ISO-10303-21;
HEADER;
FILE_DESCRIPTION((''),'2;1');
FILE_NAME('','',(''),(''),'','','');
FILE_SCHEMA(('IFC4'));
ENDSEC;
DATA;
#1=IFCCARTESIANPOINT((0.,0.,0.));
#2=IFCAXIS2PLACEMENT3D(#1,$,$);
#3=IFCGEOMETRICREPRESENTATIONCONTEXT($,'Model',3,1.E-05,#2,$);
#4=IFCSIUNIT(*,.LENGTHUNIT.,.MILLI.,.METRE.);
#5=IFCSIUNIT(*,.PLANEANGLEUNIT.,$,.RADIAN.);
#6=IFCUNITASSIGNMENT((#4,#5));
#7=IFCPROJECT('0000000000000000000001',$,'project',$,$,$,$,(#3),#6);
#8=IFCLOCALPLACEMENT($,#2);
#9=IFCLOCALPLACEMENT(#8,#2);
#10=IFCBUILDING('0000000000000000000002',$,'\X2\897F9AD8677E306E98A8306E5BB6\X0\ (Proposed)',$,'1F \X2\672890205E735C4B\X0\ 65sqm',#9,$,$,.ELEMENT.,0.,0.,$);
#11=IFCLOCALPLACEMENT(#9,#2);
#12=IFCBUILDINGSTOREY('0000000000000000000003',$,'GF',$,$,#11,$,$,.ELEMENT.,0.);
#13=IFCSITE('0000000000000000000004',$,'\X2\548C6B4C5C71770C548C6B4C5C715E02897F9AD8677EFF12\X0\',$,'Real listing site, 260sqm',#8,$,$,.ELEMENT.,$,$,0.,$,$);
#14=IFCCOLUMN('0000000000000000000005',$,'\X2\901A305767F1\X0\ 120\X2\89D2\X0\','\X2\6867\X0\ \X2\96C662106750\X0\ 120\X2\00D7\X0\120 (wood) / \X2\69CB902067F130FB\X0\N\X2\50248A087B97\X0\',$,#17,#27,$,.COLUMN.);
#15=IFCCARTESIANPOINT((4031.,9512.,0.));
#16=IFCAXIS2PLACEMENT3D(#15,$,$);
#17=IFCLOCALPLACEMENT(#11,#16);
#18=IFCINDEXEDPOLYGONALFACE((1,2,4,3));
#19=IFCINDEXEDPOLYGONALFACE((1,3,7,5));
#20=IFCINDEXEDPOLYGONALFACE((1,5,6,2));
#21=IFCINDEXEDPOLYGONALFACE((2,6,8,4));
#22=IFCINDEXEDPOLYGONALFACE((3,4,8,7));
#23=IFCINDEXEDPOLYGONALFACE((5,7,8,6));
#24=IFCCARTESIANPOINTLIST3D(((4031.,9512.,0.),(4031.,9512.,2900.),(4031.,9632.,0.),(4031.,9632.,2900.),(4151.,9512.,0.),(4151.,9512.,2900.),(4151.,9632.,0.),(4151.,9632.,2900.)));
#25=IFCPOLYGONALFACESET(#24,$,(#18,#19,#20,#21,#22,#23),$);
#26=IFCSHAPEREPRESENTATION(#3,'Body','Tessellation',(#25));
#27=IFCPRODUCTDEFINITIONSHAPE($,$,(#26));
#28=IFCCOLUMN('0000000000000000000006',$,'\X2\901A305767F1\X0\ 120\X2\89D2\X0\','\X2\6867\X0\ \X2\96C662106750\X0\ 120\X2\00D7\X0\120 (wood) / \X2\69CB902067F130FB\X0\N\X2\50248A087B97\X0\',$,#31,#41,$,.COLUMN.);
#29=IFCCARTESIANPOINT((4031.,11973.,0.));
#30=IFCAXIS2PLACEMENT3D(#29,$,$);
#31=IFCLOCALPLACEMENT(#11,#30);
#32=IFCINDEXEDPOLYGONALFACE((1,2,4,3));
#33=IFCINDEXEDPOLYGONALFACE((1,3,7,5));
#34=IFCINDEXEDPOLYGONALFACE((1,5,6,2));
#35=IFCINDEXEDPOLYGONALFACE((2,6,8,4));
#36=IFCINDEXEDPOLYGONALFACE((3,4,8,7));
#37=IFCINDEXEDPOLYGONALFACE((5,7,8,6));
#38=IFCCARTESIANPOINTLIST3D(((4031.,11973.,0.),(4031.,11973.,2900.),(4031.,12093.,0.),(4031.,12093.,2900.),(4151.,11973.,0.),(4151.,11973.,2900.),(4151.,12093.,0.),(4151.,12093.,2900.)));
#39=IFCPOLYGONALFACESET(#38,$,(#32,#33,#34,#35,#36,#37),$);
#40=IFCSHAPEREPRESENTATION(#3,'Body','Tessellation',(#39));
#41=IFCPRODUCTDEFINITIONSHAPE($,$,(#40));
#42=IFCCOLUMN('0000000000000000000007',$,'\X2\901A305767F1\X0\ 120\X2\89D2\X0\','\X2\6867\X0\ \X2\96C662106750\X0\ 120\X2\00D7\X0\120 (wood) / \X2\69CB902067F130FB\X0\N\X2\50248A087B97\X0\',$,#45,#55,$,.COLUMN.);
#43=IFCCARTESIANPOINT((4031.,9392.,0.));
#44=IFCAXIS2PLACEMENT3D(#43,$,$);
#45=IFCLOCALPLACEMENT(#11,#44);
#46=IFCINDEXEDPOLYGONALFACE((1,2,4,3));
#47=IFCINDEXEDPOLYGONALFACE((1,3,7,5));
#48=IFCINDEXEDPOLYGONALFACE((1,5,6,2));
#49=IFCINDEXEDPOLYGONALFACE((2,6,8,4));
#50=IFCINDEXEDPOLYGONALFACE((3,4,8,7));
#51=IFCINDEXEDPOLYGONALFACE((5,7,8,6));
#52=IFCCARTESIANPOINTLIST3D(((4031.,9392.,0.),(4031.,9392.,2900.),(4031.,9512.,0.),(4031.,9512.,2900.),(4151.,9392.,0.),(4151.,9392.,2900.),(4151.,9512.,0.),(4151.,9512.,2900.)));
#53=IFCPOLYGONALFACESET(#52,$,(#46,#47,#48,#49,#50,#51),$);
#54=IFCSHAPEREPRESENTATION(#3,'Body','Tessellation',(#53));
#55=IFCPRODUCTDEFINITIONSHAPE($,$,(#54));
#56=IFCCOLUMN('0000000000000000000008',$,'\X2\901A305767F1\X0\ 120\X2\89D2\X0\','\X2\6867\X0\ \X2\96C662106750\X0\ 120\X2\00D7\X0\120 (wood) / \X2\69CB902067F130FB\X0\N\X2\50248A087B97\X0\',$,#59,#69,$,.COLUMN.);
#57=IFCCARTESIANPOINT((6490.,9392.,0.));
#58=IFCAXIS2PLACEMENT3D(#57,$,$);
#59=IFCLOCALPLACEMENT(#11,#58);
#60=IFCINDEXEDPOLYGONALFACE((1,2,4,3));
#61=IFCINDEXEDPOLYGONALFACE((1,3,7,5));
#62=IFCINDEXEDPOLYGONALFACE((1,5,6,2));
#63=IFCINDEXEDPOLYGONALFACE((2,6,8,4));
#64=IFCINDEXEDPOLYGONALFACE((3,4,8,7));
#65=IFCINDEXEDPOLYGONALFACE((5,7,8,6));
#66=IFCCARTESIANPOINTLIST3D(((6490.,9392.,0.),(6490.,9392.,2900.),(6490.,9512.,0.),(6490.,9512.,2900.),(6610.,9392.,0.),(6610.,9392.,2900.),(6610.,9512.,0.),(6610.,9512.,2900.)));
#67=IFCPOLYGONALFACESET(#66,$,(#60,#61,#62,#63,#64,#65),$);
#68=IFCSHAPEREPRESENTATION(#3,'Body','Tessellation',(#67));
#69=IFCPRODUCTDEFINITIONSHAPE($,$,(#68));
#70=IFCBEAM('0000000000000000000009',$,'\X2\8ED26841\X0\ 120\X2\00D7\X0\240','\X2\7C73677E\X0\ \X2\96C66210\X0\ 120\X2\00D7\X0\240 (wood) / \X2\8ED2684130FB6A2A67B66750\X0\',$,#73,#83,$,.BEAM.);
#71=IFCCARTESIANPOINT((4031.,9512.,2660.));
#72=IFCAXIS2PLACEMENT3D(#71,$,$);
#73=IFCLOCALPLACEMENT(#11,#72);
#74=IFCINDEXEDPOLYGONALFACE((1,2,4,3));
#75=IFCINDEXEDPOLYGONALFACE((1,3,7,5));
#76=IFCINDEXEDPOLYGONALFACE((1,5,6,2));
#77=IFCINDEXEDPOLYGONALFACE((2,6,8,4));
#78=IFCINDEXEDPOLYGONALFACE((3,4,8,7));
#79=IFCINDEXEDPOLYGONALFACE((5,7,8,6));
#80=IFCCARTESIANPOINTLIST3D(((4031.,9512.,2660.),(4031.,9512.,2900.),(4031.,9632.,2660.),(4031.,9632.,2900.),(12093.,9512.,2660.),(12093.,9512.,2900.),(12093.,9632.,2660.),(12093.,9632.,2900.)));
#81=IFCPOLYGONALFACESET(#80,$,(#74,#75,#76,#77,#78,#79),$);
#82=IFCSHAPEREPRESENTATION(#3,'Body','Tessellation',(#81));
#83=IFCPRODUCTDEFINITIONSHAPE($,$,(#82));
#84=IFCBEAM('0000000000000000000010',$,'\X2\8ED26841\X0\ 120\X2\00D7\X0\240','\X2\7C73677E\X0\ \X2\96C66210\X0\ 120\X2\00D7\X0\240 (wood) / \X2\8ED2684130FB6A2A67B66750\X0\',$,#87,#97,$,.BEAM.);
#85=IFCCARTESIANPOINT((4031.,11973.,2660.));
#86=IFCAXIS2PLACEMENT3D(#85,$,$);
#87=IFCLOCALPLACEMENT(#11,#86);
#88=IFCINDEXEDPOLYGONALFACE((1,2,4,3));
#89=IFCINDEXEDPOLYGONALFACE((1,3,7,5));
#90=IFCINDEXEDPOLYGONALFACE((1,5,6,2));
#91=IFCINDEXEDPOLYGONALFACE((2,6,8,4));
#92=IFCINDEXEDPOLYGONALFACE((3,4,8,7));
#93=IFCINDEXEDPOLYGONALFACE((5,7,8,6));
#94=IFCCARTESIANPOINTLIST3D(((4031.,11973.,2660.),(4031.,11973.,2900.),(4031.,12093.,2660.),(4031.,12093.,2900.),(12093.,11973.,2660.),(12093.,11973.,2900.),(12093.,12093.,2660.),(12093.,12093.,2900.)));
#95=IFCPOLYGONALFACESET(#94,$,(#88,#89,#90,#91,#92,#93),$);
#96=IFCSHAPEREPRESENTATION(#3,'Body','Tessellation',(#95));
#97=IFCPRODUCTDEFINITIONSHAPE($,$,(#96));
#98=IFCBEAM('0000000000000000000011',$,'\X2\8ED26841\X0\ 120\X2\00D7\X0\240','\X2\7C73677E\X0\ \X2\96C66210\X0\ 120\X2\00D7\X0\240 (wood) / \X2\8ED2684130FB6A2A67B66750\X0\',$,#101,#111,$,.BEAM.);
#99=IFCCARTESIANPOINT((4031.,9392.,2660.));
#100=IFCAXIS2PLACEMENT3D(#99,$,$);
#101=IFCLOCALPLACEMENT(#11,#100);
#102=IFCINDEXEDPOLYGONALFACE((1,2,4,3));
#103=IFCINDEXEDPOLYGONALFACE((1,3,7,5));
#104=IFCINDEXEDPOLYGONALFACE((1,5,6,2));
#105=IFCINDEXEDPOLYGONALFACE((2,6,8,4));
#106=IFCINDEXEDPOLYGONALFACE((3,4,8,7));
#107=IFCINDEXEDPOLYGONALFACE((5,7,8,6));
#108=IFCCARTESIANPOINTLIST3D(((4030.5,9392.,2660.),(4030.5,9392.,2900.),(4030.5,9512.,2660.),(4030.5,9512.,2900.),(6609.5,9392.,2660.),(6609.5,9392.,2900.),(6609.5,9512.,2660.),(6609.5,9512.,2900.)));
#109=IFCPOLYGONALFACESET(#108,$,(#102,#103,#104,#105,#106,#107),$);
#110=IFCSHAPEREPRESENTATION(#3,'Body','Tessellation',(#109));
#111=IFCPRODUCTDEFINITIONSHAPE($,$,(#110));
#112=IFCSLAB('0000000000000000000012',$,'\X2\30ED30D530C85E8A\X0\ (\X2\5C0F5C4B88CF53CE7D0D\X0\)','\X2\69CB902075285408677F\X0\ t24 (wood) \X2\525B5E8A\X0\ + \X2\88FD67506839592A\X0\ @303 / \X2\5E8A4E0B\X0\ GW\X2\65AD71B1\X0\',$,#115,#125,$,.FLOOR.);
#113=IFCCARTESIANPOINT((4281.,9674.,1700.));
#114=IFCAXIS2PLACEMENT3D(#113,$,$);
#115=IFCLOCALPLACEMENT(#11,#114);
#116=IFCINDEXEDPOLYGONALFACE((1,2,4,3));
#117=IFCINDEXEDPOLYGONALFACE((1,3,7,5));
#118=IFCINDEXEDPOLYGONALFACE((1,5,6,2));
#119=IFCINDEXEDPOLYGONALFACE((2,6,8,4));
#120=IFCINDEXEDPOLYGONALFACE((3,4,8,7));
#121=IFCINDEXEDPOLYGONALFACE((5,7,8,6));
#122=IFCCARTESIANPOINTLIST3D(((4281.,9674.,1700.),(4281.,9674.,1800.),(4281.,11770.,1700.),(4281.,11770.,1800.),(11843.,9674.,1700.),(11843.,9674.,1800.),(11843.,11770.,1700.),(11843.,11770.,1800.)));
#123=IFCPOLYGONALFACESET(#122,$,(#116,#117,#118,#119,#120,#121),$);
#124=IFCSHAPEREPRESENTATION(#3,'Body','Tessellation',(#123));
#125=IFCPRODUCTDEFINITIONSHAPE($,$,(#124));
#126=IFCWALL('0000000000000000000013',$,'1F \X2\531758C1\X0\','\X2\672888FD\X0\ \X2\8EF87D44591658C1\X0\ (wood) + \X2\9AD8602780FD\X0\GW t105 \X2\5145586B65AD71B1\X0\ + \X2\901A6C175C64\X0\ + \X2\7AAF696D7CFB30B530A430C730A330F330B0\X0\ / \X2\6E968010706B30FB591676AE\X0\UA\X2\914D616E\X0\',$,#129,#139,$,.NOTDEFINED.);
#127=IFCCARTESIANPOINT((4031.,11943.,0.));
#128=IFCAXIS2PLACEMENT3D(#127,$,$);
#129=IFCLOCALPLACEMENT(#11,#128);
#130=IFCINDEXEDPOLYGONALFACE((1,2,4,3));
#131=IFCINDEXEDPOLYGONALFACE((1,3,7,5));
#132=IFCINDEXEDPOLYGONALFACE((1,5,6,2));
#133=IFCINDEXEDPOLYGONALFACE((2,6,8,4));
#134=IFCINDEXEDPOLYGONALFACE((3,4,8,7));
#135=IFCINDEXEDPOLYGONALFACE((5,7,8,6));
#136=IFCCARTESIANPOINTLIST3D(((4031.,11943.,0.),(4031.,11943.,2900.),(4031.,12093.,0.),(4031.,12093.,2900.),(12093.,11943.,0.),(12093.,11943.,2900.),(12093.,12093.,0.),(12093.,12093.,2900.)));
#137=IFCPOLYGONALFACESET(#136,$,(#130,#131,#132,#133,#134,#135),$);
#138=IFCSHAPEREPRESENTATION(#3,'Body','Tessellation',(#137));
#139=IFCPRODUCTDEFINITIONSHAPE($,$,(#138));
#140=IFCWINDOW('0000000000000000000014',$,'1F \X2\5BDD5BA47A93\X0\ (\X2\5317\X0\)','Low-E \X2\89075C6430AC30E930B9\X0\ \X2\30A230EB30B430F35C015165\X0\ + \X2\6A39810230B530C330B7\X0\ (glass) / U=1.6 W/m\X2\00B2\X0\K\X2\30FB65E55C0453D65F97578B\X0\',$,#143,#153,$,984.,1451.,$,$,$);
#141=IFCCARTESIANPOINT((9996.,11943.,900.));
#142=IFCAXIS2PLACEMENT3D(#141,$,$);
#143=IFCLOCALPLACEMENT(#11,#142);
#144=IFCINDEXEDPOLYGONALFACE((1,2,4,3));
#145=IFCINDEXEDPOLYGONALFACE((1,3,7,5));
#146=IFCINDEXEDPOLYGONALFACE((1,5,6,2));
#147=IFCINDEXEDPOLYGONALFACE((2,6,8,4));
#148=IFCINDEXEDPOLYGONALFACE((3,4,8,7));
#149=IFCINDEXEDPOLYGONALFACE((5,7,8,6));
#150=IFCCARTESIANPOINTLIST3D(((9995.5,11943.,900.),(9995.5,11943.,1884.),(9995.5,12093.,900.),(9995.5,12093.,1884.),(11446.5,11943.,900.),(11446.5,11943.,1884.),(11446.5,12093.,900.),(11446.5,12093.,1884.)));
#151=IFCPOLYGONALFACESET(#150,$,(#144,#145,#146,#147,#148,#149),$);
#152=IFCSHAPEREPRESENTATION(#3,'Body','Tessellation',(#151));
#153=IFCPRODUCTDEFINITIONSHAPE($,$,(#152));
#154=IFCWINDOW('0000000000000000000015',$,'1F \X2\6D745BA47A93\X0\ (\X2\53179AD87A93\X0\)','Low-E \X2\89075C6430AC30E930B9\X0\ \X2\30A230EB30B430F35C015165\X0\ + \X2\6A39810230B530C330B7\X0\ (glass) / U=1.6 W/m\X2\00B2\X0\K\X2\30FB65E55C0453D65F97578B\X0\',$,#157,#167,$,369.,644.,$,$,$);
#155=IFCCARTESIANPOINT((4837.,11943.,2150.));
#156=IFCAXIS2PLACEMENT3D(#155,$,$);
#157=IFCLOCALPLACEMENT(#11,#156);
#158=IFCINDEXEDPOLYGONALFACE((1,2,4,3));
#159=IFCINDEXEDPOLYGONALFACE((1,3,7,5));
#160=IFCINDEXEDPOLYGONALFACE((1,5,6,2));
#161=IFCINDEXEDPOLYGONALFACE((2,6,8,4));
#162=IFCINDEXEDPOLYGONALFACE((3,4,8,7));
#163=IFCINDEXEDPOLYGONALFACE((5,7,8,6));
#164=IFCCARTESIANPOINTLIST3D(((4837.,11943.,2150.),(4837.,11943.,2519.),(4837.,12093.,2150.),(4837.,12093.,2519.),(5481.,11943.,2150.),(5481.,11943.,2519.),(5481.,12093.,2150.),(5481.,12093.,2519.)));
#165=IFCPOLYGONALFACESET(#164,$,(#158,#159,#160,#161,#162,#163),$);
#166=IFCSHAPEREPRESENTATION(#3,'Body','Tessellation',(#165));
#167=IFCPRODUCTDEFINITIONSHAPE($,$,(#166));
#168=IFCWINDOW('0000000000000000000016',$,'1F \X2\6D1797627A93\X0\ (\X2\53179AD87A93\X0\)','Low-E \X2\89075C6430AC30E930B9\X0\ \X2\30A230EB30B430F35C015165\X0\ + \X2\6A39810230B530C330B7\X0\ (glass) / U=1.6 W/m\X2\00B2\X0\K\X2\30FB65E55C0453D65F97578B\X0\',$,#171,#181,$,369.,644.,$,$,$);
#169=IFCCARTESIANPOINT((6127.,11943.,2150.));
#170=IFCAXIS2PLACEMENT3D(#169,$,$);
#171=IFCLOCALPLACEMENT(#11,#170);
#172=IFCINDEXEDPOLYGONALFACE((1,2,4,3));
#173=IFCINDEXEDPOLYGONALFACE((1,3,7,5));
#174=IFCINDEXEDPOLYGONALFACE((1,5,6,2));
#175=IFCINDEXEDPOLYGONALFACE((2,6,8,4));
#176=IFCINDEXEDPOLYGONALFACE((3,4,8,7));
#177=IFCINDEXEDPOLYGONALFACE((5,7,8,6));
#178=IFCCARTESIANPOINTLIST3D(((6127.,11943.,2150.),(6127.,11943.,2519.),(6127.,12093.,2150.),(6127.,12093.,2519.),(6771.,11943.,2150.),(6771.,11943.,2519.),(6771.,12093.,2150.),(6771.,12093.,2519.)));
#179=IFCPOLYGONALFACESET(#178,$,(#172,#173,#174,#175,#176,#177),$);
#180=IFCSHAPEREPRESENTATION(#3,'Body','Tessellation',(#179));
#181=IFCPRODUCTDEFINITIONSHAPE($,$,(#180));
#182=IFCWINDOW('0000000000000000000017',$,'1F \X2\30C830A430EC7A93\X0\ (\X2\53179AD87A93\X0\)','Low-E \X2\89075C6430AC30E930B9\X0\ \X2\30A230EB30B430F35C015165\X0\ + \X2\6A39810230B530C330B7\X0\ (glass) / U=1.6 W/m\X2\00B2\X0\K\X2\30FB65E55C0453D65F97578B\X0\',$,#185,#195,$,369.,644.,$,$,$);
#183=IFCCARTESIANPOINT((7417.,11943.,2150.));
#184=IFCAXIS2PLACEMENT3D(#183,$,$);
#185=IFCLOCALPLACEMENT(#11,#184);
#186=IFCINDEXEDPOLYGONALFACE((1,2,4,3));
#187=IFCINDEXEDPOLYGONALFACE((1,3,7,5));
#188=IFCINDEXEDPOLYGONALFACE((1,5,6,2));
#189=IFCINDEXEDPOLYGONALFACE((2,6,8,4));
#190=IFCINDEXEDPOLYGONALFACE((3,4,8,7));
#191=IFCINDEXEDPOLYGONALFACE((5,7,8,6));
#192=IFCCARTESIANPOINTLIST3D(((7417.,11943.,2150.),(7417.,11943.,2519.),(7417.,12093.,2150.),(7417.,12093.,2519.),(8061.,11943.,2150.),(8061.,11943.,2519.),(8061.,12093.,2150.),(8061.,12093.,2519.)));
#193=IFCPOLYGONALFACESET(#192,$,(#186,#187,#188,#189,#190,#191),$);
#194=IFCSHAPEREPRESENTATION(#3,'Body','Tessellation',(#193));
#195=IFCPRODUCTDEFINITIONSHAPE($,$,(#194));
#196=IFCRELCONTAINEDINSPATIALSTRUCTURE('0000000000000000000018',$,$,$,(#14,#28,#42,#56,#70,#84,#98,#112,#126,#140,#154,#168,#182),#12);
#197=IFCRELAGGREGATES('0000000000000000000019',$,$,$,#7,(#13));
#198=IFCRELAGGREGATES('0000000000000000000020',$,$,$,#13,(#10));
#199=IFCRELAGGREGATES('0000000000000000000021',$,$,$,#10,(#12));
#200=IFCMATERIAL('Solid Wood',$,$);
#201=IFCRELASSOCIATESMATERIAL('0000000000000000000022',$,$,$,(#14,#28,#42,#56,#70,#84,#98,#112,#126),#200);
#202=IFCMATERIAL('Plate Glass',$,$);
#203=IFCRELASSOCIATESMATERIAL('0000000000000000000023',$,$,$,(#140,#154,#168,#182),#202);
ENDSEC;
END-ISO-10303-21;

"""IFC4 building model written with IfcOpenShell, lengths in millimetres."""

from ifc_helpers import new_model, si_unit, frame, frame_2d, origin, place, context, project, spatial, rectangle, extrude, material, element, fill, save


model = new_model("IFC4")

# Units and contexts
model_context = context("Model", 3, precision=1e-05, world=origin())
ifc_project = project(units=[si_unit("LENGTHUNIT", "METRE", prefix="MILLI"), si_unit("PLANEANGLEUNIT", "RADIAN")], contexts=[model_context])

# Site, building, storey
site_placement = place(None, origin())
site = spatial("IfcSite", under=ifc_project, at=site_placement, Name="和歌山県和歌山市西高松２", ObjectType="Real listing site, 260sqm", CompositionType="ELEMENT", RefElevation=0.0)
building_placement = place(site_placement, origin())
building = spatial("IfcBuilding", under=site, at=building_placement, Name="西高松の風の家 (Proposed)", ObjectType="1F 木造平屋 65sqm", CompositionType="ELEMENT", ElevationOfRefHeight=0.0, ElevationOfTerrain=0.0)
storey_placement = place(building_placement, origin())
storey = spatial("IfcBuildingStorey", under=building, at=storey_placement, Name="GF", CompositionType="ELEMENT", Elevation=0.0)

# Columns
ifc_material_1 = material(Name="Solid Wood")
column_1_placement = place(storey_placement, frame((4031.0, 9512.0, 0.0)))
element("IfcColumn", 1, at=column_1_placement, inside=storey, material=ifc_material_1, Name="通し柱 120角", Description="桧 集成材 120×120 (wood) / 構造柱・N値計算", PredefinedType="COLUMN", context=model_context, shape_type="SweptSolid", body=[
    extrude(rectangle(XDim=120.0, YDim=120.0, at=frame_2d((60.0, 60.0))), frame((4031.0, 9512.0, 0.0)), (0.0, 0.0, 1.0), 2900.0),
])
column_2_placement = place(storey_placement, frame((4031.0, 11973.0, 0.0)))
element("IfcColumn", 2, at=column_2_placement, inside=storey, material=ifc_material_1, Name="通し柱 120角", Description="桧 集成材 120×120 (wood) / 構造柱・N値計算", PredefinedType="COLUMN", context=model_context, shape_type="SweptSolid", body=[
    extrude(rectangle(XDim=120.0, YDim=120.0, at=frame_2d((60.0, 60.0))), frame((4031.0, 11973.0, 0.0)), (0.0, 0.0, 1.0), 2900.0),
])
column_3_placement = place(storey_placement, frame((4031.0, 9392.0, 0.0)))
element("IfcColumn", 3, at=column_3_placement, inside=storey, material=ifc_material_1, Name="通し柱 120角", Description="桧 集成材 120×120 (wood) / 構造柱・N値計算", PredefinedType="COLUMN", context=model_context, shape_type="SweptSolid", body=[
    extrude(rectangle(XDim=120.0, YDim=120.0, at=frame_2d((60.0, 60.0))), frame((4031.0, 9392.0, 0.0)), (0.0, 0.0, 1.0), 2900.0),
])
column_4_placement = place(storey_placement, frame((6490.0, 9392.0, 0.0)))
element("IfcColumn", 4, at=column_4_placement, inside=storey, material=ifc_material_1, Name="通し柱 120角", Description="桧 集成材 120×120 (wood) / 構造柱・N値計算", PredefinedType="COLUMN", context=model_context, shape_type="SweptSolid", body=[
    extrude(rectangle(XDim=120.0, YDim=120.0, at=frame_2d((60.0, 60.0))), frame((6490.0, 9392.0, 0.0)), (0.0, 0.0, 1.0), 2900.0),
])

# Beams
beam_1_placement = place(storey_placement, frame((4031.0, 9512.0, 2660.0)))
element("IfcBeam", 5, at=beam_1_placement, inside=storey, material=ifc_material_1, Name="軒桁 120×240", Description="米松 集成 120×240 (wood) / 軒桁・横架材", PredefinedType="BEAM", context=model_context, shape_type="SweptSolid", body=[
    extrude(rectangle(XDim=8062.0, YDim=120.0, at=frame_2d((4031.0, 60.0))), frame((4031.0, 9512.0, 2660.0)), (0.0, 0.0, 1.0), 240.0),
])
beam_2_placement = place(storey_placement, frame((4031.0, 11973.0, 2660.0)))
element("IfcBeam", 6, at=beam_2_placement, inside=storey, material=ifc_material_1, Name="軒桁 120×240", Description="米松 集成 120×240 (wood) / 軒桁・横架材", PredefinedType="BEAM", context=model_context, shape_type="SweptSolid", body=[
    extrude(rectangle(XDim=8062.0, YDim=120.0, at=frame_2d((4031.0, 60.0))), frame((4031.0, 11973.0, 2660.0)), (0.0, 0.0, 1.0), 240.0),
])
beam_3_placement = place(storey_placement, frame((4031.0, 9392.0, 2660.0)))
element("IfcBeam", 7, at=beam_3_placement, inside=storey, material=ifc_material_1, Name="軒桁 120×240", Description="米松 集成 120×240 (wood) / 軒桁・横架材", PredefinedType="BEAM", context=model_context, shape_type="SweptSolid", body=[
    extrude(rectangle(XDim=2579.0, YDim=120.0, at=frame_2d((1289.0, 60.0))), frame((4031.0, 9392.0, 2660.0)), (0.0, 0.0, 1.0), 240.0),
])

# Slab
slab_1_placement = place(storey_placement, frame((4281.0, 9674.0, 1700.0)))
element("IfcSlab", 8, at=slab_1_placement, inside=storey, material=ifc_material_1, Name="ロフト床 (小屋裏収納)", Description="構造用合板 t24 (wood) 剛床 + 製材根太 @303 / 床下 GW断熱", PredefinedType="FLOOR", context=model_context, shape_type="SweptSolid", body=[
    extrude(rectangle(XDim=7562.0, YDim=2096.0, at=frame_2d((3781.0, 1048.0))), frame((4281.0, 9674.0, 1700.0)), (0.0, 0.0, 1.0), 100.0),
])

# Wall, openings, windows
wall_1_placement = place(storey_placement, frame((4031.0, 11943.0, 0.0)))
wall_1 = element("IfcWall", 9, at=wall_1_placement, inside=storey, material=ifc_material_1, Name="1F 北壁", Description="木製 軸組外壁 (wood) + 高性能GW t105 充填断熱 + 通気層 + 窯業系サイディング / 準耐火・外皮UA配慮", PredefinedType="NOTDEFINED", context=model_context, shape_type="SweptSolid", body=[
    extrude(rectangle(XDim=8062.0, YDim=150.0, at=frame_2d((4031.0, 75.0))), frame((4031.0, 11943.0, 0.0)), (0.0, 0.0, 1.0), 2900.0),
])
opening_1_placement = place(storey_placement, frame((9996.0, 11943.0, 900.0)))
opening_1 = element("IfcOpeningElement", 10, at=opening_1_placement, cuts=wall_1, PredefinedType="NOTDEFINED", context=model_context, shape_type="SweptSolid", body=[
    extrude(rectangle(XDim=1451.0, YDim=150.0, at=frame_2d((725.0, 75.0))), frame((9996.0, 11943.0, 900.0)), (0.0, 0.0, 1.0), 984.0),
])
opening_2_placement = place(storey_placement, frame((4837.0, 11943.0, 2150.0)))
opening_2 = element("IfcOpeningElement", 11, at=opening_2_placement, cuts=wall_1, PredefinedType="NOTDEFINED", context=model_context, shape_type="SweptSolid", body=[
    extrude(rectangle(XDim=644.0, YDim=150.0, at=frame_2d((322.0, 75.0))), frame((4837.0, 11943.0, 2150.0)), (0.0, 0.0, 1.0), 369.0),
])
opening_3_placement = place(storey_placement, frame((6127.0, 11943.0, 2150.0)))
opening_3 = element("IfcOpeningElement", 12, at=opening_3_placement, cuts=wall_1, PredefinedType="NOTDEFINED", context=model_context, shape_type="SweptSolid", body=[
    extrude(rectangle(XDim=644.0, YDim=150.0, at=frame_2d((322.0, 75.0))), frame((6127.0, 11943.0, 2150.0)), (0.0, 0.0, 1.0), 369.0),
])
opening_4_placement = place(storey_placement, frame((7417.0, 11943.0, 2150.0)))
opening_4 = element("IfcOpeningElement", 13, at=opening_4_placement, cuts=wall_1, PredefinedType="NOTDEFINED", context=model_context, shape_type="SweptSolid", body=[
    extrude(rectangle(XDim=644.0, YDim=150.0, at=frame_2d((322.0, 75.0))), frame((7417.0, 11943.0, 2150.0)), (0.0, 0.0, 1.0), 369.0),
])
ifc_material_2 = material(Name="Plate Glass")
window_1_placement = place(storey_placement, frame((9996.0, 11943.0, 900.0)))
window_1 = element("IfcWindow", 14, at=window_1_placement, inside=storey, material=ifc_material_2, Name="1F 寝室窓 (北)", Description="Low-E 複層ガラス アルゴン封入 + 樹脂サッシ (glass) / U=1.6 W/m²K・日射取得型", OverallHeight=984.0, OverallWidth=1451.0, context=model_context, shape_type="SweptSolid", body=[
    extrude(rectangle(XDim=1451.0, YDim=150.0, at=frame_2d((725.0, 75.0))), frame((9996.0, 11943.0, 900.0)), (0.0, 0.0, 1.0), 984.0),
])
fill(opening_1, window_1)
window_2_placement = place(storey_placement, frame((4837.0, 11943.0, 2150.0)))
window_2 = element("IfcWindow", 15, at=window_2_placement, inside=storey, material=ifc_material_2, Name="1F 浴室窓 (北高窓)", Description="Low-E 複層ガラス アルゴン封入 + 樹脂サッシ (glass) / U=1.6 W/m²K・日射取得型", OverallHeight=369.0, OverallWidth=644.0, context=model_context, shape_type="SweptSolid", body=[
    extrude(rectangle(XDim=644.0, YDim=150.0, at=frame_2d((322.0, 75.0))), frame((4837.0, 11943.0, 2150.0)), (0.0, 0.0, 1.0), 369.0),
])
fill(opening_2, window_2)
window_3_placement = place(storey_placement, frame((6127.0, 11943.0, 2150.0)))
window_3 = element("IfcWindow", 16, at=window_3_placement, inside=storey, material=ifc_material_2, Name="1F 洗面窓 (北高窓)", Description="Low-E 複層ガラス アルゴン封入 + 樹脂サッシ (glass) / U=1.6 W/m²K・日射取得型", OverallHeight=369.0, OverallWidth=644.0, context=model_context, shape_type="SweptSolid", body=[
    extrude(rectangle(XDim=644.0, YDim=150.0, at=frame_2d((322.0, 75.0))), frame((6127.0, 11943.0, 2150.0)), (0.0, 0.0, 1.0), 369.0),
])
fill(opening_3, window_3)
window_4_placement = place(storey_placement, frame((7417.0, 11943.0, 2150.0)))
window_4 = element("IfcWindow", 17, at=window_4_placement, inside=storey, material=ifc_material_2, Name="1F トイレ窓 (北高窓)", Description="Low-E 複層ガラス アルゴン封入 + 樹脂サッシ (glass) / U=1.6 W/m²K・日射取得型", OverallHeight=369.0, OverallWidth=644.0, context=model_context, shape_type="SweptSolid", body=[
    extrude(rectangle(XDim=644.0, YDim=150.0, at=frame_2d((322.0, 75.0))), frame((7417.0, 11943.0, 2150.0)), (0.0, 0.0, 1.0), 369.0),
])
fill(opening_4, window_4)

save(model, "model.ifc")
